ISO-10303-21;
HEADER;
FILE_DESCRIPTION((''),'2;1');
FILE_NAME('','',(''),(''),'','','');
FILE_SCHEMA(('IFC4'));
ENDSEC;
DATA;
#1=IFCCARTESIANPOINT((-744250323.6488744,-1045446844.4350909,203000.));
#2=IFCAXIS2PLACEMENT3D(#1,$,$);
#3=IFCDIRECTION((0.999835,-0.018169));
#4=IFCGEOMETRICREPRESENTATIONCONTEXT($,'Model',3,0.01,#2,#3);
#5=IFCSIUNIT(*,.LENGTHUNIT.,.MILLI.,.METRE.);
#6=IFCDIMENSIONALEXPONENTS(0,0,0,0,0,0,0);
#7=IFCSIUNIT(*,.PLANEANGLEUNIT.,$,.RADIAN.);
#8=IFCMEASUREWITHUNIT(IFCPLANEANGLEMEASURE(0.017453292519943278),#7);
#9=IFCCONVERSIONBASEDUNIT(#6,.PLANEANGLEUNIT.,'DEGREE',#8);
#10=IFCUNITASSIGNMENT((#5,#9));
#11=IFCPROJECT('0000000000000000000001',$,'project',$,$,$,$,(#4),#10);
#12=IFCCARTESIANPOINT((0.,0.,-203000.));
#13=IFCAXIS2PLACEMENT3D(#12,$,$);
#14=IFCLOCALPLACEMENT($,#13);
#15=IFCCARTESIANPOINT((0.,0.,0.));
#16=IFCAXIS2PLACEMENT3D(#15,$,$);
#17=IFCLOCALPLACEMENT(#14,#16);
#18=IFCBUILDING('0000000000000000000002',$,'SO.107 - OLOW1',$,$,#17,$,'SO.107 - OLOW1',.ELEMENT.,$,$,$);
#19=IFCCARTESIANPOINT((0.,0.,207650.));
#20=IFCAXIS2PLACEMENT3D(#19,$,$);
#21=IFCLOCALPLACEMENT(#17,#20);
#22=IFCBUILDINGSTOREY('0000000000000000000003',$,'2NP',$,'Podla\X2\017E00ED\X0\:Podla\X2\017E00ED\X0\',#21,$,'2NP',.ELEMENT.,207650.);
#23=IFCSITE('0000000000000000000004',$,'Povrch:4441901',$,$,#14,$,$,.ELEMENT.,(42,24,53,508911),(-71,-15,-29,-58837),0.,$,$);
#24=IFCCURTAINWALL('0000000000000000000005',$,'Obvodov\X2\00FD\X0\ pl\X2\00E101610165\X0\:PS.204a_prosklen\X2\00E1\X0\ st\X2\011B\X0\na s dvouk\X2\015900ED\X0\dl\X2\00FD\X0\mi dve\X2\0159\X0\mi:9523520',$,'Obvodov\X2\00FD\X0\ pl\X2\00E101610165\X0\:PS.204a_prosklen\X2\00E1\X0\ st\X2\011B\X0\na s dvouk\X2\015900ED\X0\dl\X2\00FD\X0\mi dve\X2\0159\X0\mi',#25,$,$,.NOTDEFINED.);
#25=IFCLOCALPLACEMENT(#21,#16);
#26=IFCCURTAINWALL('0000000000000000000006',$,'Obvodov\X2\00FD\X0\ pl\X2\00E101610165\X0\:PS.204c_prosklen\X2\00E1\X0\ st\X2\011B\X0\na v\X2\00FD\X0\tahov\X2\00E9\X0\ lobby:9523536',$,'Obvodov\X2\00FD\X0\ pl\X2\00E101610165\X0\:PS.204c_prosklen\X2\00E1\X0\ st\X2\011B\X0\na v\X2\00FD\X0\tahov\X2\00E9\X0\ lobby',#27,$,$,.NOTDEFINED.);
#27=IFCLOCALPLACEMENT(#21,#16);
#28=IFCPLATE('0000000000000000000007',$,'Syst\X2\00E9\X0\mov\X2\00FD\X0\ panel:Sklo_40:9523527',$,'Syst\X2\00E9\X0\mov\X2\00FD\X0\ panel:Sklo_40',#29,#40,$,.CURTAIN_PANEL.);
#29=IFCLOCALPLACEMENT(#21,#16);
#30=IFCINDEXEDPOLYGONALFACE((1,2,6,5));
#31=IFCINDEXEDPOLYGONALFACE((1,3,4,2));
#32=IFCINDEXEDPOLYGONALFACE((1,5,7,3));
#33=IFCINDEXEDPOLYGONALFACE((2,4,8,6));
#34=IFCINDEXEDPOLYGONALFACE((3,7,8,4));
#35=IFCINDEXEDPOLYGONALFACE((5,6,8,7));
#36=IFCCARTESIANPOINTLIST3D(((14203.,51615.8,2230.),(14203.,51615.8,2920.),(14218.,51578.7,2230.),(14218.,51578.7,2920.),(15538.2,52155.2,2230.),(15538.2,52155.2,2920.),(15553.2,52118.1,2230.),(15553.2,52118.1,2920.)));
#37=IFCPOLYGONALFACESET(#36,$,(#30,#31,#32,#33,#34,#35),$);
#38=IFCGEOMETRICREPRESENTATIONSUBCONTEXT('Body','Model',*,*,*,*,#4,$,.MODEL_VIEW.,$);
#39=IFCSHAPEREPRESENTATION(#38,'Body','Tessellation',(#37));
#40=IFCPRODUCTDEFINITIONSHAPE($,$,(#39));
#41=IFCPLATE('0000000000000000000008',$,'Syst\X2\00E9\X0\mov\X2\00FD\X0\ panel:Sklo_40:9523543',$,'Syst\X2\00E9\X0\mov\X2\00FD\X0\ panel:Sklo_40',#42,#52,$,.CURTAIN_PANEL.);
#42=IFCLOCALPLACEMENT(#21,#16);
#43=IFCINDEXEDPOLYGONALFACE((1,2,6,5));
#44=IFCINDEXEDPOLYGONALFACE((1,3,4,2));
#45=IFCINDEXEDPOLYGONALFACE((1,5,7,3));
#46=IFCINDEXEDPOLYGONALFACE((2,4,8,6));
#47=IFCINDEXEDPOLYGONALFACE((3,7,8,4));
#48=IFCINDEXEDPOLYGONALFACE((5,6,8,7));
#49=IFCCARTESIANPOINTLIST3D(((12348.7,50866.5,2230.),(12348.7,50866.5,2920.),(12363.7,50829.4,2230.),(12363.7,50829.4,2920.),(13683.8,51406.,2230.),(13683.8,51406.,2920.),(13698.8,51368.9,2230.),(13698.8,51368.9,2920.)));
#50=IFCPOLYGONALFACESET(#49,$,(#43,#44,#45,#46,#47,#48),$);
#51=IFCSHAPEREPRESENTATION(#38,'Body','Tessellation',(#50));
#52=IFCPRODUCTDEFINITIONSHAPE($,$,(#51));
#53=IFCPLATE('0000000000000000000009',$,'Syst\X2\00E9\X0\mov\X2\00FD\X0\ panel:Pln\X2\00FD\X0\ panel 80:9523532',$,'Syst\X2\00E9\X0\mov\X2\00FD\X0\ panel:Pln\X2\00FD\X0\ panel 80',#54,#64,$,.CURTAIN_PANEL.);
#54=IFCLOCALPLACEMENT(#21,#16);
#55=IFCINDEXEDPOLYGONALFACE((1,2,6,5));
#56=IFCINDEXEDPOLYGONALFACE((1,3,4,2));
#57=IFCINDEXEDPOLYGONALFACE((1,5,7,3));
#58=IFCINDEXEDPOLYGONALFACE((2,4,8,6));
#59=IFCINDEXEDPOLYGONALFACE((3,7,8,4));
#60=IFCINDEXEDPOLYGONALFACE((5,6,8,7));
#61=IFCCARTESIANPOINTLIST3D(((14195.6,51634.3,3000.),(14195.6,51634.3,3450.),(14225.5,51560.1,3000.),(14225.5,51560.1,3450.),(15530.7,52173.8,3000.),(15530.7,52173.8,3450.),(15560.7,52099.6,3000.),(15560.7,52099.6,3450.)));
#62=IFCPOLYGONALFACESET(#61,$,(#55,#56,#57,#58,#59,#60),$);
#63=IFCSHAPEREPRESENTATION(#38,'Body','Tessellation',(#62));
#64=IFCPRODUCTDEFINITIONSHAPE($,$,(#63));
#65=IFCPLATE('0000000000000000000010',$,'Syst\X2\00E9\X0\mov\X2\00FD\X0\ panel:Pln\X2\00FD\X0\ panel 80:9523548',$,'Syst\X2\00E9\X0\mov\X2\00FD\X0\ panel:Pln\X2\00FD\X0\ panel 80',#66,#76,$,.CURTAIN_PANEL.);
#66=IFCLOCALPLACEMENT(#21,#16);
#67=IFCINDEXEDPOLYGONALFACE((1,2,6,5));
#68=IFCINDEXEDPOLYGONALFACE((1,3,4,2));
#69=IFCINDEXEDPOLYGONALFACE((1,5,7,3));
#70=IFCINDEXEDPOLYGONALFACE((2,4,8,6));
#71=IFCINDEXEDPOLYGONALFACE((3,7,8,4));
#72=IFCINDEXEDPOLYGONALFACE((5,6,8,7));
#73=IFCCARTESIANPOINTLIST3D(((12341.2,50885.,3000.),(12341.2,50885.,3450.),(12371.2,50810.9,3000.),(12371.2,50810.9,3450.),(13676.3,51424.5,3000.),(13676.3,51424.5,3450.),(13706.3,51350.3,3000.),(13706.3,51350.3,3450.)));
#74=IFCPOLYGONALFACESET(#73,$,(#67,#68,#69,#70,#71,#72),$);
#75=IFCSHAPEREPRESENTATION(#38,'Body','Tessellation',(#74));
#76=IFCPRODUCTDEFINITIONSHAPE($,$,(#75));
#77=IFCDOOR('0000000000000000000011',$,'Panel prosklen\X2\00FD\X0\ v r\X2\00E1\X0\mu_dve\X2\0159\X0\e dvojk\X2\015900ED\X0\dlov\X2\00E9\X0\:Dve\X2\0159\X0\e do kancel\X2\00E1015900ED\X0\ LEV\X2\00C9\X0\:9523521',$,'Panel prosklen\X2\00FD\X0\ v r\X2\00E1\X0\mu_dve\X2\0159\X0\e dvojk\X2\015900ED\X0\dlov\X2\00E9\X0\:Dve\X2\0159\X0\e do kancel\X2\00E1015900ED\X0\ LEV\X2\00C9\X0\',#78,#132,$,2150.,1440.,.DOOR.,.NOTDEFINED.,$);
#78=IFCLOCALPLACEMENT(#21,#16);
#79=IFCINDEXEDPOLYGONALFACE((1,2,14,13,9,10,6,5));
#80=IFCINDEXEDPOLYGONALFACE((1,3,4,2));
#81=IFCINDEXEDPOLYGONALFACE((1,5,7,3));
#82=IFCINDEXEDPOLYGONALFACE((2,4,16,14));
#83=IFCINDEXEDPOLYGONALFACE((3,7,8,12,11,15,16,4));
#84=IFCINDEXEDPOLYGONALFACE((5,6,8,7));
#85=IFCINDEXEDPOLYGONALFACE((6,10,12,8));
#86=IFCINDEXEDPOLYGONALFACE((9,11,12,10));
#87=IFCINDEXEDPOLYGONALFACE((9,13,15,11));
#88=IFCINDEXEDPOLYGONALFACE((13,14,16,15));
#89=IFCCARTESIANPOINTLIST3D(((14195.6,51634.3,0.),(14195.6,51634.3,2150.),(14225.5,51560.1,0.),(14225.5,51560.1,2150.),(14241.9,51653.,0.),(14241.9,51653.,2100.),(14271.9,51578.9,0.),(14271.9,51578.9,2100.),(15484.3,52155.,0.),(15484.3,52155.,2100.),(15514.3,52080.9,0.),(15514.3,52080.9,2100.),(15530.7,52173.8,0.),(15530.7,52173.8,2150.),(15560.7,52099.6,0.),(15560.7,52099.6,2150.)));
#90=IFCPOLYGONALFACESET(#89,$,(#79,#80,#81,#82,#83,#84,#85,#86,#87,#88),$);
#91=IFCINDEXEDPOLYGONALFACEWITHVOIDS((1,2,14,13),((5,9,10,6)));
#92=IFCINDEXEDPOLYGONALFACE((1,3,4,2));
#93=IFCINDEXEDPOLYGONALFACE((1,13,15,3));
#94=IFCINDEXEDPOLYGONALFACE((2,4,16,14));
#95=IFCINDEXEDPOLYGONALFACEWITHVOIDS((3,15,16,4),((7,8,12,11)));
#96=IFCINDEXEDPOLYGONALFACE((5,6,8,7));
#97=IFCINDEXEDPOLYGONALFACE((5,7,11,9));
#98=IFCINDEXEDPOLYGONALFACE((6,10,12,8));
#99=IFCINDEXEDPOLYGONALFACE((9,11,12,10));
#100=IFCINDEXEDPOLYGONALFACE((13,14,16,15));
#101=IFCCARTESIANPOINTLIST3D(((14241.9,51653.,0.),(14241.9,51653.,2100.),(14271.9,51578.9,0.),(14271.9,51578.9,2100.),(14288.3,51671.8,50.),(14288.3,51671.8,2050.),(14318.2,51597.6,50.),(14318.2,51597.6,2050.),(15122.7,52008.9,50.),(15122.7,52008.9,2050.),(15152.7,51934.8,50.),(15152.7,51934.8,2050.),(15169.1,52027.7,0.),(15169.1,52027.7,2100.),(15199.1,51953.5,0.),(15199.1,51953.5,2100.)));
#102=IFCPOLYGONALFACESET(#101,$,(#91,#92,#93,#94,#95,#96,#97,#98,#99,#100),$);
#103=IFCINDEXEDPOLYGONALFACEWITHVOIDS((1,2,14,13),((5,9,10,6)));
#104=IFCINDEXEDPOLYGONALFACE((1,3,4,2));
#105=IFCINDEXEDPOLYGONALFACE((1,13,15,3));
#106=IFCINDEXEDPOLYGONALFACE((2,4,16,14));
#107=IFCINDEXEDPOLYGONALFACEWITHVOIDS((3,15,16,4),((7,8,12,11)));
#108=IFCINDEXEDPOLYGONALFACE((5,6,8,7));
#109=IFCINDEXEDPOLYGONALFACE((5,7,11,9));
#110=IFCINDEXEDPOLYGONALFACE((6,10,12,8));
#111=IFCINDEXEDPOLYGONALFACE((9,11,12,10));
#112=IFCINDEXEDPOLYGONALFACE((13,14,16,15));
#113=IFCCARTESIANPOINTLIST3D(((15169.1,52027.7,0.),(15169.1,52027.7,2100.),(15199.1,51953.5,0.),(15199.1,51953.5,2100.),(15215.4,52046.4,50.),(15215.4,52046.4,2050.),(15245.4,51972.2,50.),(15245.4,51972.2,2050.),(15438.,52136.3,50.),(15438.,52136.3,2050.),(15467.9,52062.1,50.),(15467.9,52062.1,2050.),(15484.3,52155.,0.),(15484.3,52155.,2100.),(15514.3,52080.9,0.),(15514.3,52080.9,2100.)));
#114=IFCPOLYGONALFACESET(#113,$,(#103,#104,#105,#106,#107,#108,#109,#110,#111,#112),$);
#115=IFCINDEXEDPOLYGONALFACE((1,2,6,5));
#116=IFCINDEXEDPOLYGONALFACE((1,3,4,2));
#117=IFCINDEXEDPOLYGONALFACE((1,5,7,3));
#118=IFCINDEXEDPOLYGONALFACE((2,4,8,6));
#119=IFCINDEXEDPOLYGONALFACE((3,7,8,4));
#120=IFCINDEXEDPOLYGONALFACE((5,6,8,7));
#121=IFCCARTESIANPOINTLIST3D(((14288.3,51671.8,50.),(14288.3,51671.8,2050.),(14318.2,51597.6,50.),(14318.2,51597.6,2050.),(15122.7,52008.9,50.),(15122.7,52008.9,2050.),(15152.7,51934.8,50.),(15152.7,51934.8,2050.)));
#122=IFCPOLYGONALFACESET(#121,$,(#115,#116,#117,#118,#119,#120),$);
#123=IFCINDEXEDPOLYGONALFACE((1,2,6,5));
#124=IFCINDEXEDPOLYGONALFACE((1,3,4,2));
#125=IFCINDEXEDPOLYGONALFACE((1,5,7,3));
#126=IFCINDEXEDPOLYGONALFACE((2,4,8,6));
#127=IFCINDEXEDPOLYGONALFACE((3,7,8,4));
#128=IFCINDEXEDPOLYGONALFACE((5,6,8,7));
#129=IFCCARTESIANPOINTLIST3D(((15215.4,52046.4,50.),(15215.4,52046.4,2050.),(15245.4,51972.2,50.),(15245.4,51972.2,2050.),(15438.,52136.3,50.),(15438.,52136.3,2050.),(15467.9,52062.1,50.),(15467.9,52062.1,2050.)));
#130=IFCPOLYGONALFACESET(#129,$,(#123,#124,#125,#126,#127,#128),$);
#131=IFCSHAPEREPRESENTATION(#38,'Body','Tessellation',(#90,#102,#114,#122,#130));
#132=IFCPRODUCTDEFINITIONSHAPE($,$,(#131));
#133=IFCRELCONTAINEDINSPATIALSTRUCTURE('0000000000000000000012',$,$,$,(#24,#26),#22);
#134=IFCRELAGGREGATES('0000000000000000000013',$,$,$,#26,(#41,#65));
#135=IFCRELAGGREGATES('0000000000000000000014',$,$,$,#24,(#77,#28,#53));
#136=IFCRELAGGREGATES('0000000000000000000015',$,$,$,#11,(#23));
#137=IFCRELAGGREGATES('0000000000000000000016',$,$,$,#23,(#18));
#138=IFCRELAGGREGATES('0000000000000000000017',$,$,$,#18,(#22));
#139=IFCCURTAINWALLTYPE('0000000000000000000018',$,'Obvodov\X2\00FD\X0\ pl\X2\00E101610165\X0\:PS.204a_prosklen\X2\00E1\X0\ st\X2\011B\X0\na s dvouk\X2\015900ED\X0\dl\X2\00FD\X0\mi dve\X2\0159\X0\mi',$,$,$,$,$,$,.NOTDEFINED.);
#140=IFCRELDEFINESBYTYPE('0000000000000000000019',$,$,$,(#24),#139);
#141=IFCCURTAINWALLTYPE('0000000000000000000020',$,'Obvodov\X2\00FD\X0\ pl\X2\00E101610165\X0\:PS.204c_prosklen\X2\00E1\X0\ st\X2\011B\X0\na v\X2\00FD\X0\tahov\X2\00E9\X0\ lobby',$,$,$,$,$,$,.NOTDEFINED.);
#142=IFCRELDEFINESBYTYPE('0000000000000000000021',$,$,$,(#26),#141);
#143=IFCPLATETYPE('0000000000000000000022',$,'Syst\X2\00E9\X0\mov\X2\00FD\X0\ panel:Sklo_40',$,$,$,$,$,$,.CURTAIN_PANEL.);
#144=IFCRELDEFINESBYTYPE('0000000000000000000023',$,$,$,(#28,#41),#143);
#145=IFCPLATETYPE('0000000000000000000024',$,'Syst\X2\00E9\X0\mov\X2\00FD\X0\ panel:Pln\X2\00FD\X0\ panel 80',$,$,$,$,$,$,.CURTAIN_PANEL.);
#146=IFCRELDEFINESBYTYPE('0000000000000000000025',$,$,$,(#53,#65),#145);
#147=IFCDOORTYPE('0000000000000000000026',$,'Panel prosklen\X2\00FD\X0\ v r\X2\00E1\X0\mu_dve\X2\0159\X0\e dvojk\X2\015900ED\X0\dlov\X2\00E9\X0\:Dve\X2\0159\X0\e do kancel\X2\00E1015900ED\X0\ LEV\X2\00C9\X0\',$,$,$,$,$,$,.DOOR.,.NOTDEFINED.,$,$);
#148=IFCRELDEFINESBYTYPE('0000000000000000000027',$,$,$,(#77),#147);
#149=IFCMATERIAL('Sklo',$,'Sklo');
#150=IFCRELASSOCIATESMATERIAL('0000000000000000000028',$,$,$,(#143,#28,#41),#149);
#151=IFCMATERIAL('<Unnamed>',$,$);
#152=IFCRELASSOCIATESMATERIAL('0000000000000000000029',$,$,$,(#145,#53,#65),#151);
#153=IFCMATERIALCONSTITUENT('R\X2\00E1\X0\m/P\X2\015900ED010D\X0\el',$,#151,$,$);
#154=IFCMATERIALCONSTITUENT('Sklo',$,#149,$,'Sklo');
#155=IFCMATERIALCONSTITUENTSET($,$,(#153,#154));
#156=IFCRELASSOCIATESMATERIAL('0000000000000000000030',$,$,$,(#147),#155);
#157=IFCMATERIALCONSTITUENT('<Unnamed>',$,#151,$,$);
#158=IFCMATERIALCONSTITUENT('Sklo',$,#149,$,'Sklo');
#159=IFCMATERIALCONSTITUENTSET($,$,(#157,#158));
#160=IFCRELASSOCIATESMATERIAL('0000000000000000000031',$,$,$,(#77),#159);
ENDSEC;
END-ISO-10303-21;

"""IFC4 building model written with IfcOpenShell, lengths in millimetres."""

from ifc_helpers import new_model, entity, si_unit, converted_unit, direction, frame, origin, place, context, subcontext, project, spatial, indexed_curve, outline, extrude, source, transform, mapped, material, constituent, constituent_set, type_object, type_shapes, element, aggregate, save


model = new_model("IFC4")

# Units and contexts
model_context = context("Model", 3, precision=0.01, world=frame((-744250323.6488744, -1045446844.4350909, 203000.0)), true_north=direction((0.999835, -0.018169)))
body_context = subcontext(model_context, "Body", "Model", "MODEL_VIEW")
ifc_project = project(units=[si_unit("LENGTHUNIT", "METRE", prefix="MILLI"), converted_unit("PLANEANGLEUNIT", "DEGREE", entity("IfcPlaneAngleMeasure", 0.017453292519943278), si_unit("PLANEANGLEUNIT", "RADIAN"), dimensions=[0, 0, 0, 0, 0, 0, 0])], contexts=[model_context])

# Site, building, storey
site_placement = place(None, frame((0.0, 0.0, -203000.0)))
site = spatial("IfcSite", under=ifc_project, at=site_placement, Name="Povrch:4441901", CompositionType="ELEMENT", RefLatitude=(42, 24, 53, 508911), RefLongitude=(-71, -15, -29, -58837), RefElevation=0.0)
building_placement = place(site_placement, origin())
building = spatial("IfcBuilding", under=site, at=building_placement, Name="SO.107 - OLOW1", LongName="SO.107 - OLOW1", CompositionType="ELEMENT")
storey_placement = place(building_placement, frame((0.0, 0.0, 207650.0)))
storey = spatial("IfcBuildingStorey", under=building, at=storey_placement, Name="2NP", ObjectType="Podlaží:Podlaží", LongName="2NP", CompositionType="ELEMENT", Elevation=207650.0)

# Curtain walls
curtain_wall_type_1 = type_object("IfcCurtainWallType", Name="Obvodový plášť:PS.204a_prosklená stěna s dvoukřídlými dveřmi", PredefinedType="NOTDEFINED")
curtain_wall_1_placement = place(storey_placement, frame((0.0, 0.0, -207650.0)))
curtain_wall_1 = element("IfcCurtainWall", 1, at=curtain_wall_1_placement, inside=storey, type_object=curtain_wall_type_1, Name="Obvodový plášť:PS.204a_prosklená stěna s dvoukřídlými dveřmi:9523520", ObjectType="Obvodový plášť:PS.204a_prosklená stěna s dvoukřídlými dveřmi", PredefinedType="NOTDEFINED")
ifc_material_1 = material(Name="<Unnamed>")
curtain_wall_type_2 = type_object("IfcCurtainWallType", Name="Obvodový plášť:PS.204c_prosklená stěna výtahové lobby", PredefinedType="NOTDEFINED")
curtain_wall_2_placement = place(storey_placement, frame((0.0, 0.0, -207650.0)))
curtain_wall_2 = element("IfcCurtainWall", 2, at=curtain_wall_2_placement, inside=storey, type_object=curtain_wall_type_2, Name="Obvodový plášť:PS.204c_prosklená stěna výtahové lobby:9523536", ObjectType="Obvodový plášť:PS.204c_prosklená stěna výtahové lobby", PredefinedType="NOTDEFINED")

# Plates
ifc_material_2 = material(Name="Sklo", Category="Sklo")
plate_type_1 = type_object("IfcPlateType", Name="Systémový panel:Sklo_40", PredefinedType="CURTAIN_PANEL", material=ifc_material_2)
shared_shape_1 = source(origin(), body_context, "Body", "SweptSolid", [
    extrude(outline(indexed_curve([(-20.0, -720.0), (20.0, -720.0), (20.0, 720.0), (-20.0, 720.0), (-20.0, -720.0)], self_intersect=False)), frame((0.0, 0.0, 0.0), z_axis=(0.0, 0.0, 1.0), x_axis=(0.0, 1.0, 0.0)), (0.0, 0.0, 1.0), 690.0),
])
type_shapes(plate_type_1, [shared_shape_1])
plate_1_placement = place(curtain_wall_1_placement, frame((14878.1, 51866.9, 209880.0), z_axis=(0.0, 0.0, 1.0), x_axis=(-0.927176, -0.374626, 0.0)))
plate_1 = element("IfcPlate", 3, at=plate_1_placement, type_object=plate_type_1, material=ifc_material_2, Name="Systémový panel:Sklo_40:9523527", ObjectType="Systémový panel:Sklo_40", PredefinedType="CURTAIN_PANEL", context=body_context, shape_type="MappedRepresentation", body=[
    mapped(shared_shape_1, transform((0.0, 0.0, 0.0), scale=1.0)),
])
plate_2_placement = place(curtain_wall_2_placement, frame((13023.8, 51117.7, 209880.0), z_axis=(0.0, 0.0, 1.0), x_axis=(0.927176, 0.374626, 0.0)))
plate_2 = element("IfcPlate", 4, at=plate_2_placement, type_object=plate_type_1, material=ifc_material_2, Name="Systémový panel:Sklo_40:9523543", ObjectType="Systémový panel:Sklo_40", PredefinedType="CURTAIN_PANEL", context=body_context, shape_type="MappedRepresentation", body=[
    mapped(shared_shape_1, transform((0.0, 0.0, 0.0), scale=1.0)),
])
plate_type_2 = type_object("IfcPlateType", Name="Systémový panel:Plný panel 80", PredefinedType="CURTAIN_PANEL", material=ifc_material_1)
shared_shape_2 = source(origin(), body_context, "Body", "SweptSolid", [
    extrude(outline(indexed_curve([(-40.0, -720.0), (40.0, -720.0), (40.0, 720.0), (-40.0, 720.0), (-40.0, -720.0)], self_intersect=False)), frame((0.0, 0.0, 0.0), z_axis=(0.0, 0.0, 1.0), x_axis=(0.0, 1.0, 0.0)), (0.0, 0.0, 1.0), 450.0),
])
type_shapes(plate_type_2, [shared_shape_2])
plate_3_placement = place(curtain_wall_1_placement, frame((14878.1, 51866.9, 210650.0), z_axis=(0.0, 0.0, 1.0), x_axis=(-0.927176, -0.374626, 0.0)))
plate_3 = element("IfcPlate", 5, at=plate_3_placement, type_object=plate_type_2, material=ifc_material_1, Name="Systémový panel:Plný panel 80:9523532", ObjectType="Systémový panel:Plný panel 80", PredefinedType="CURTAIN_PANEL", context=body_context, shape_type="MappedRepresentation", body=[
    mapped(shared_shape_2, transform((0.0, 0.0, 0.0), scale=1.0)),
])
plate_4_placement = place(curtain_wall_2_placement, frame((13023.8, 51117.7, 210650.0), z_axis=(0.0, 0.0, 1.0), x_axis=(0.927176, 0.374626, 0.0)))
plate_4 = element("IfcPlate", 6, at=plate_4_placement, type_object=plate_type_2, material=ifc_material_1, Name="Systémový panel:Plný panel 80:9523548", ObjectType="Systémový panel:Plný panel 80", PredefinedType="CURTAIN_PANEL", context=body_context, shape_type="MappedRepresentation", body=[
    mapped(shared_shape_2, transform((0.0, 0.0, 0.0), scale=1.0)),
])
aggregate(curtain_wall_2, [plate_2, plate_4])

# Door
ifc_constituent_1 = constituent(ifc_material_1, Name="<Unnamed>")
ifc_constituent_2 = constituent(ifc_material_2, Name="Sklo", Category="Sklo")
ifc_constituent_set_1 = constituent_set(constituents=[ifc_constituent_1, ifc_constituent_2])
ifc_constituent_3 = constituent(ifc_material_1, Name="Rám/Příčel")
ifc_constituent_4 = constituent(ifc_material_2, Name="Sklo", Category="Sklo")
ifc_constituent_set_2 = constituent_set(constituents=[ifc_constituent_3, ifc_constituent_4])
door_type = type_object("IfcDoorType", Name="Panel prosklený v rámu_dveře dvojkřídlové:Dveře do kanceláří LEVÉ", OperationType="NOTDEFINED", PredefinedType="DOOR", material=ifc_constituent_set_2)
shared_shape_3 = source(origin(), body_context, "Body", "SweptSolid", [
    extrude(outline(indexed_curve([(-720.0, -1087.5), (720.0, -1087.5), (720.0, 1062.5), (670.0, 1062.5), (670.0, -1037.5), (-670.0, -1037.5), (-670.0, 1062.5), (-720.0, 1062.5), (-720.0, -1087.5)], self_intersect=False)), frame((0.0, 40.0, 1062.5), z_axis=(0.0, -1.0, 0.0), x_axis=(-1.0, 0.0, 0.0)), (0.0, 0.0, 1.0), 80.0),
    extrude(outline(indexed_curve([(-1050.0, -500.0), (1050.0, -500.0), (1050.0, 500.0), (-1050.0, 500.0), (-1050.0, -500.0)], self_intersect=False), holes=[indexed_curve([(-1000.0, -450.0), (-1000.0, 450.0), (1000.0, 450.0), (1000.0, -450.0), (-1000.0, -450.0)], self_intersect=False)]), frame((-170.0, 40.0, 1050.0), z_axis=(0.0, -1.0, 0.0), x_axis=(0.0, 0.0, -1.0)), (0.0, 0.0, 1.0), 80.0),
    extrude(outline(indexed_curve([(-1050.0, -170.0), (1050.0, -170.0), (1050.0, 170.0), (-1050.0, 170.0), (-1050.0, -170.0)], self_intersect=False), holes=[indexed_curve([(-1000.0, -120.0), (-1000.0, 120.0), (1000.0, 120.0), (1000.0, -120.0), (-1000.0, -120.0)], self_intersect=False)]), frame((500.0, 40.0, 1050.0), z_axis=(0.0, -1.0, 0.0), x_axis=(0.0, 0.0, -1.0)), (0.0, 0.0, 1.0), 80.0),
    extrude(outline(indexed_curve([(-450.0, -40.0), (450.0, -40.0), (450.0, 40.0), (-450.0, 40.0), (-450.0, -40.0)], self_intersect=False)), frame((-170.0, 0.0, 50.0)), (0.0, 0.0, 1.0), 2000.0),
    extrude(outline(indexed_curve([(-120.0, -40.0), (120.0, -40.0), (120.0, 40.0), (-120.0, 40.0), (-120.0, -40.0)], self_intersect=False)), frame((500.0, 0.0, 50.0)), (0.0, 0.0, 1.0), 2000.0),
])
type_shapes(door_type, [shared_shape_3])
door_placement = place(curtain_wall_1_placement, frame((14878.1, 51866.9, 207650.0), z_axis=(0.0, 0.0, 1.0), x_axis=(0.927176, 0.374626, 0.0)))
door = element("IfcDoor", 7, at=door_placement, type_object=door_type, material=ifc_constituent_set_1, Name="Panel prosklený v rámu_dveře dvojkřídlové:Dveře do kanceláří LEVÉ:9523521", ObjectType="Panel prosklený v rámu_dveře dvojkřídlové:Dveře do kanceláří LEVÉ", OperationType="NOTDEFINED", OverallHeight=2150.0, OverallWidth=1440.0, PredefinedType="DOOR", context=body_context, shape_type="MappedRepresentation", body=[
    mapped(shared_shape_3, transform((0.0, 0.0, 0.0), scale=1.0)),
])
aggregate(curtain_wall_1, [door, plate_1, plate_3])

save(model, "model.ifc")
